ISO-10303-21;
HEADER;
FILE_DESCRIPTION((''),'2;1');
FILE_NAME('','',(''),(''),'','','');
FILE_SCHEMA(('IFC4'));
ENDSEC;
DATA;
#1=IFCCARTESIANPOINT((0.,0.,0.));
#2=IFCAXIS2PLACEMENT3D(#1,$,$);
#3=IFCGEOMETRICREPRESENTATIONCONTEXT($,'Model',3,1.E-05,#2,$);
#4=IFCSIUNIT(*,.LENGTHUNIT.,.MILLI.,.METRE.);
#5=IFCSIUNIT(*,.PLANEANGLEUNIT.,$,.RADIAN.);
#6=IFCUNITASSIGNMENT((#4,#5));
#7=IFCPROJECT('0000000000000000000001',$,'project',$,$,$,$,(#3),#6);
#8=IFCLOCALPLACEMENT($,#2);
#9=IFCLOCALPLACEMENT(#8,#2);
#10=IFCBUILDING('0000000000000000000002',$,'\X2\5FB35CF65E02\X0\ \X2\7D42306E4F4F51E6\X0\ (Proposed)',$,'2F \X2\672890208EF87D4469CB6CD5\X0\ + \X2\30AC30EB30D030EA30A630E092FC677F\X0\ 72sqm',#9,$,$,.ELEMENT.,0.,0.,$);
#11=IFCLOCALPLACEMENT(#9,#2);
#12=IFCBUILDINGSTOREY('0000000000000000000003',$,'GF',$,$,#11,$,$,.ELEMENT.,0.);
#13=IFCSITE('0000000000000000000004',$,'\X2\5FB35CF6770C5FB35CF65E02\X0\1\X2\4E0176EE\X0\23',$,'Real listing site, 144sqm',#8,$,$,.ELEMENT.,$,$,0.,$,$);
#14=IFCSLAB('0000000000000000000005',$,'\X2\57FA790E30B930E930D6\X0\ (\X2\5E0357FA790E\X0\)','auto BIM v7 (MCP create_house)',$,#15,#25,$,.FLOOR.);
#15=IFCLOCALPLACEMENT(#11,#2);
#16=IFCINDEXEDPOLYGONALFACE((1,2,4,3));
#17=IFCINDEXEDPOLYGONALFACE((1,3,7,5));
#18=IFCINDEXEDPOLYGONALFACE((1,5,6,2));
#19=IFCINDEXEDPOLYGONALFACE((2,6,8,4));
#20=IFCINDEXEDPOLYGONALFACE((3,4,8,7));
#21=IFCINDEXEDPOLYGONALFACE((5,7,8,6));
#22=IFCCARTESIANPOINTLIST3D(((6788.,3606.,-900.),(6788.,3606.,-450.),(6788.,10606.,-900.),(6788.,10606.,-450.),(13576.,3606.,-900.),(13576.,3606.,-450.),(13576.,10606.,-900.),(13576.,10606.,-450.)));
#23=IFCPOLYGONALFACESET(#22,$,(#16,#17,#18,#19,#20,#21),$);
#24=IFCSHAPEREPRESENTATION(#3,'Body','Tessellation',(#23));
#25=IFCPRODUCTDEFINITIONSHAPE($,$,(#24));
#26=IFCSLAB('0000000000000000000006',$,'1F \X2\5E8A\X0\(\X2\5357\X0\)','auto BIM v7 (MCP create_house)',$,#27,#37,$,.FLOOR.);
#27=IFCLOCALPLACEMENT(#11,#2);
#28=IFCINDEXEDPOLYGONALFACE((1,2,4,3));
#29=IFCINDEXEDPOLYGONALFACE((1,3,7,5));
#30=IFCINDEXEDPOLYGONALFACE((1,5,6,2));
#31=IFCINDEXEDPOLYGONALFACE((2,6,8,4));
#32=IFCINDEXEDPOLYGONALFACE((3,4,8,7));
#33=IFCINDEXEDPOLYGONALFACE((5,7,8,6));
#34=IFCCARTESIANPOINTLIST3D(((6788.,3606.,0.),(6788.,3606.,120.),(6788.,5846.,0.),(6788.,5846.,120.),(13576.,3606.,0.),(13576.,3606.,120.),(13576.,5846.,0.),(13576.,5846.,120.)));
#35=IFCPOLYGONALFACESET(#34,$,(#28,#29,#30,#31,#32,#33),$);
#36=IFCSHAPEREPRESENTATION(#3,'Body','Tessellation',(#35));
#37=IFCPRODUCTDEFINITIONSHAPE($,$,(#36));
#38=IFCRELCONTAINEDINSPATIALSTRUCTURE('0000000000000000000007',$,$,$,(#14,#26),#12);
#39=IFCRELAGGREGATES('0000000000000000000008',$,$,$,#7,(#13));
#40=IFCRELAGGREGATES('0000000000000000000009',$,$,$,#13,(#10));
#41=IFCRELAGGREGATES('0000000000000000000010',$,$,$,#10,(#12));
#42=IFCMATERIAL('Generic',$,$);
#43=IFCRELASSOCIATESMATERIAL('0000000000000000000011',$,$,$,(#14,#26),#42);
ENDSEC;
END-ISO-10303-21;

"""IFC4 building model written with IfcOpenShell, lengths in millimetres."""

from ifc_helpers import new_model, si_unit, frame, frame_2d, origin, place, context, project, spatial, rectangle, extrude, material, element, save


model = new_model("IFC4")

# Units and contexts
model_context = context("Model", 3, precision=1e-05, world=origin())
ifc_project = project(units=[si_unit("LENGTHUNIT", "METRE", prefix="MILLI"), si_unit("PLANEANGLEUNIT", "RADIAN")], contexts=[model_context])

# Site, building, storey
site_placement = place(None, origin())
site = spatial("IfcSite", under=ifc_project, at=site_placement, Name="徳島県徳島市1丁目23", ObjectType="Real listing site, 144sqm", CompositionType="ELEMENT", RefElevation=0.0)
building_placement = place(site_placement, origin())
building = spatial("IfcBuilding", under=site, at=building_placement, Name="徳島市 終の住処 (Proposed)", ObjectType="2F 木造軸組構法 + ガルバリウム鋼板 72sqm", CompositionType="ELEMENT", ElevationOfRefHeight=0.0, ElevationOfTerrain=0.0)
storey_placement = place(building_placement, origin())
storey = spatial("IfcBuildingStorey", under=building, at=storey_placement, Name="GF", CompositionType="ELEMENT", Elevation=0.0)

# Slabs
ifc_material = material(Name="Generic")
slab_1_placement = place(storey_placement, frame((3394.0, 1803.0, -450.0)))
element("IfcSlab", 1, at=slab_1_placement, inside=storey, material=ifc_material, Name="基礎スラブ (布基礎)", Description="auto BIM v7 (MCP create_house)", PredefinedType="FLOOR", context=model_context, shape_type="SweptSolid", body=[
    extrude(rectangle(XDim=6788.0, YDim=7000.0, at=frame_2d((3394.0, 3500.0))), frame((3394.0, 1803.0, -450.0)), (0.0, 0.0, 1.0), 450.0),
])
slab_2_placement = place(storey_placement, frame((3394.0, 1803.0, 0.0)))
element("IfcSlab", 2, at=slab_2_placement, inside=storey, material=ifc_material, Name="1F 床(南)", Description="auto BIM v7 (MCP create_house)", PredefinedType="FLOOR", context=model_context, shape_type="SweptSolid", body=[
    extrude(rectangle(XDim=6788.0, YDim=2240.0, at=frame_2d((3394.0, 1120.0))), frame((3394.0, 1803.0, 0.0)), (0.0, 0.0, 1.0), 120.0),
])

save(model, "model.ifc")
